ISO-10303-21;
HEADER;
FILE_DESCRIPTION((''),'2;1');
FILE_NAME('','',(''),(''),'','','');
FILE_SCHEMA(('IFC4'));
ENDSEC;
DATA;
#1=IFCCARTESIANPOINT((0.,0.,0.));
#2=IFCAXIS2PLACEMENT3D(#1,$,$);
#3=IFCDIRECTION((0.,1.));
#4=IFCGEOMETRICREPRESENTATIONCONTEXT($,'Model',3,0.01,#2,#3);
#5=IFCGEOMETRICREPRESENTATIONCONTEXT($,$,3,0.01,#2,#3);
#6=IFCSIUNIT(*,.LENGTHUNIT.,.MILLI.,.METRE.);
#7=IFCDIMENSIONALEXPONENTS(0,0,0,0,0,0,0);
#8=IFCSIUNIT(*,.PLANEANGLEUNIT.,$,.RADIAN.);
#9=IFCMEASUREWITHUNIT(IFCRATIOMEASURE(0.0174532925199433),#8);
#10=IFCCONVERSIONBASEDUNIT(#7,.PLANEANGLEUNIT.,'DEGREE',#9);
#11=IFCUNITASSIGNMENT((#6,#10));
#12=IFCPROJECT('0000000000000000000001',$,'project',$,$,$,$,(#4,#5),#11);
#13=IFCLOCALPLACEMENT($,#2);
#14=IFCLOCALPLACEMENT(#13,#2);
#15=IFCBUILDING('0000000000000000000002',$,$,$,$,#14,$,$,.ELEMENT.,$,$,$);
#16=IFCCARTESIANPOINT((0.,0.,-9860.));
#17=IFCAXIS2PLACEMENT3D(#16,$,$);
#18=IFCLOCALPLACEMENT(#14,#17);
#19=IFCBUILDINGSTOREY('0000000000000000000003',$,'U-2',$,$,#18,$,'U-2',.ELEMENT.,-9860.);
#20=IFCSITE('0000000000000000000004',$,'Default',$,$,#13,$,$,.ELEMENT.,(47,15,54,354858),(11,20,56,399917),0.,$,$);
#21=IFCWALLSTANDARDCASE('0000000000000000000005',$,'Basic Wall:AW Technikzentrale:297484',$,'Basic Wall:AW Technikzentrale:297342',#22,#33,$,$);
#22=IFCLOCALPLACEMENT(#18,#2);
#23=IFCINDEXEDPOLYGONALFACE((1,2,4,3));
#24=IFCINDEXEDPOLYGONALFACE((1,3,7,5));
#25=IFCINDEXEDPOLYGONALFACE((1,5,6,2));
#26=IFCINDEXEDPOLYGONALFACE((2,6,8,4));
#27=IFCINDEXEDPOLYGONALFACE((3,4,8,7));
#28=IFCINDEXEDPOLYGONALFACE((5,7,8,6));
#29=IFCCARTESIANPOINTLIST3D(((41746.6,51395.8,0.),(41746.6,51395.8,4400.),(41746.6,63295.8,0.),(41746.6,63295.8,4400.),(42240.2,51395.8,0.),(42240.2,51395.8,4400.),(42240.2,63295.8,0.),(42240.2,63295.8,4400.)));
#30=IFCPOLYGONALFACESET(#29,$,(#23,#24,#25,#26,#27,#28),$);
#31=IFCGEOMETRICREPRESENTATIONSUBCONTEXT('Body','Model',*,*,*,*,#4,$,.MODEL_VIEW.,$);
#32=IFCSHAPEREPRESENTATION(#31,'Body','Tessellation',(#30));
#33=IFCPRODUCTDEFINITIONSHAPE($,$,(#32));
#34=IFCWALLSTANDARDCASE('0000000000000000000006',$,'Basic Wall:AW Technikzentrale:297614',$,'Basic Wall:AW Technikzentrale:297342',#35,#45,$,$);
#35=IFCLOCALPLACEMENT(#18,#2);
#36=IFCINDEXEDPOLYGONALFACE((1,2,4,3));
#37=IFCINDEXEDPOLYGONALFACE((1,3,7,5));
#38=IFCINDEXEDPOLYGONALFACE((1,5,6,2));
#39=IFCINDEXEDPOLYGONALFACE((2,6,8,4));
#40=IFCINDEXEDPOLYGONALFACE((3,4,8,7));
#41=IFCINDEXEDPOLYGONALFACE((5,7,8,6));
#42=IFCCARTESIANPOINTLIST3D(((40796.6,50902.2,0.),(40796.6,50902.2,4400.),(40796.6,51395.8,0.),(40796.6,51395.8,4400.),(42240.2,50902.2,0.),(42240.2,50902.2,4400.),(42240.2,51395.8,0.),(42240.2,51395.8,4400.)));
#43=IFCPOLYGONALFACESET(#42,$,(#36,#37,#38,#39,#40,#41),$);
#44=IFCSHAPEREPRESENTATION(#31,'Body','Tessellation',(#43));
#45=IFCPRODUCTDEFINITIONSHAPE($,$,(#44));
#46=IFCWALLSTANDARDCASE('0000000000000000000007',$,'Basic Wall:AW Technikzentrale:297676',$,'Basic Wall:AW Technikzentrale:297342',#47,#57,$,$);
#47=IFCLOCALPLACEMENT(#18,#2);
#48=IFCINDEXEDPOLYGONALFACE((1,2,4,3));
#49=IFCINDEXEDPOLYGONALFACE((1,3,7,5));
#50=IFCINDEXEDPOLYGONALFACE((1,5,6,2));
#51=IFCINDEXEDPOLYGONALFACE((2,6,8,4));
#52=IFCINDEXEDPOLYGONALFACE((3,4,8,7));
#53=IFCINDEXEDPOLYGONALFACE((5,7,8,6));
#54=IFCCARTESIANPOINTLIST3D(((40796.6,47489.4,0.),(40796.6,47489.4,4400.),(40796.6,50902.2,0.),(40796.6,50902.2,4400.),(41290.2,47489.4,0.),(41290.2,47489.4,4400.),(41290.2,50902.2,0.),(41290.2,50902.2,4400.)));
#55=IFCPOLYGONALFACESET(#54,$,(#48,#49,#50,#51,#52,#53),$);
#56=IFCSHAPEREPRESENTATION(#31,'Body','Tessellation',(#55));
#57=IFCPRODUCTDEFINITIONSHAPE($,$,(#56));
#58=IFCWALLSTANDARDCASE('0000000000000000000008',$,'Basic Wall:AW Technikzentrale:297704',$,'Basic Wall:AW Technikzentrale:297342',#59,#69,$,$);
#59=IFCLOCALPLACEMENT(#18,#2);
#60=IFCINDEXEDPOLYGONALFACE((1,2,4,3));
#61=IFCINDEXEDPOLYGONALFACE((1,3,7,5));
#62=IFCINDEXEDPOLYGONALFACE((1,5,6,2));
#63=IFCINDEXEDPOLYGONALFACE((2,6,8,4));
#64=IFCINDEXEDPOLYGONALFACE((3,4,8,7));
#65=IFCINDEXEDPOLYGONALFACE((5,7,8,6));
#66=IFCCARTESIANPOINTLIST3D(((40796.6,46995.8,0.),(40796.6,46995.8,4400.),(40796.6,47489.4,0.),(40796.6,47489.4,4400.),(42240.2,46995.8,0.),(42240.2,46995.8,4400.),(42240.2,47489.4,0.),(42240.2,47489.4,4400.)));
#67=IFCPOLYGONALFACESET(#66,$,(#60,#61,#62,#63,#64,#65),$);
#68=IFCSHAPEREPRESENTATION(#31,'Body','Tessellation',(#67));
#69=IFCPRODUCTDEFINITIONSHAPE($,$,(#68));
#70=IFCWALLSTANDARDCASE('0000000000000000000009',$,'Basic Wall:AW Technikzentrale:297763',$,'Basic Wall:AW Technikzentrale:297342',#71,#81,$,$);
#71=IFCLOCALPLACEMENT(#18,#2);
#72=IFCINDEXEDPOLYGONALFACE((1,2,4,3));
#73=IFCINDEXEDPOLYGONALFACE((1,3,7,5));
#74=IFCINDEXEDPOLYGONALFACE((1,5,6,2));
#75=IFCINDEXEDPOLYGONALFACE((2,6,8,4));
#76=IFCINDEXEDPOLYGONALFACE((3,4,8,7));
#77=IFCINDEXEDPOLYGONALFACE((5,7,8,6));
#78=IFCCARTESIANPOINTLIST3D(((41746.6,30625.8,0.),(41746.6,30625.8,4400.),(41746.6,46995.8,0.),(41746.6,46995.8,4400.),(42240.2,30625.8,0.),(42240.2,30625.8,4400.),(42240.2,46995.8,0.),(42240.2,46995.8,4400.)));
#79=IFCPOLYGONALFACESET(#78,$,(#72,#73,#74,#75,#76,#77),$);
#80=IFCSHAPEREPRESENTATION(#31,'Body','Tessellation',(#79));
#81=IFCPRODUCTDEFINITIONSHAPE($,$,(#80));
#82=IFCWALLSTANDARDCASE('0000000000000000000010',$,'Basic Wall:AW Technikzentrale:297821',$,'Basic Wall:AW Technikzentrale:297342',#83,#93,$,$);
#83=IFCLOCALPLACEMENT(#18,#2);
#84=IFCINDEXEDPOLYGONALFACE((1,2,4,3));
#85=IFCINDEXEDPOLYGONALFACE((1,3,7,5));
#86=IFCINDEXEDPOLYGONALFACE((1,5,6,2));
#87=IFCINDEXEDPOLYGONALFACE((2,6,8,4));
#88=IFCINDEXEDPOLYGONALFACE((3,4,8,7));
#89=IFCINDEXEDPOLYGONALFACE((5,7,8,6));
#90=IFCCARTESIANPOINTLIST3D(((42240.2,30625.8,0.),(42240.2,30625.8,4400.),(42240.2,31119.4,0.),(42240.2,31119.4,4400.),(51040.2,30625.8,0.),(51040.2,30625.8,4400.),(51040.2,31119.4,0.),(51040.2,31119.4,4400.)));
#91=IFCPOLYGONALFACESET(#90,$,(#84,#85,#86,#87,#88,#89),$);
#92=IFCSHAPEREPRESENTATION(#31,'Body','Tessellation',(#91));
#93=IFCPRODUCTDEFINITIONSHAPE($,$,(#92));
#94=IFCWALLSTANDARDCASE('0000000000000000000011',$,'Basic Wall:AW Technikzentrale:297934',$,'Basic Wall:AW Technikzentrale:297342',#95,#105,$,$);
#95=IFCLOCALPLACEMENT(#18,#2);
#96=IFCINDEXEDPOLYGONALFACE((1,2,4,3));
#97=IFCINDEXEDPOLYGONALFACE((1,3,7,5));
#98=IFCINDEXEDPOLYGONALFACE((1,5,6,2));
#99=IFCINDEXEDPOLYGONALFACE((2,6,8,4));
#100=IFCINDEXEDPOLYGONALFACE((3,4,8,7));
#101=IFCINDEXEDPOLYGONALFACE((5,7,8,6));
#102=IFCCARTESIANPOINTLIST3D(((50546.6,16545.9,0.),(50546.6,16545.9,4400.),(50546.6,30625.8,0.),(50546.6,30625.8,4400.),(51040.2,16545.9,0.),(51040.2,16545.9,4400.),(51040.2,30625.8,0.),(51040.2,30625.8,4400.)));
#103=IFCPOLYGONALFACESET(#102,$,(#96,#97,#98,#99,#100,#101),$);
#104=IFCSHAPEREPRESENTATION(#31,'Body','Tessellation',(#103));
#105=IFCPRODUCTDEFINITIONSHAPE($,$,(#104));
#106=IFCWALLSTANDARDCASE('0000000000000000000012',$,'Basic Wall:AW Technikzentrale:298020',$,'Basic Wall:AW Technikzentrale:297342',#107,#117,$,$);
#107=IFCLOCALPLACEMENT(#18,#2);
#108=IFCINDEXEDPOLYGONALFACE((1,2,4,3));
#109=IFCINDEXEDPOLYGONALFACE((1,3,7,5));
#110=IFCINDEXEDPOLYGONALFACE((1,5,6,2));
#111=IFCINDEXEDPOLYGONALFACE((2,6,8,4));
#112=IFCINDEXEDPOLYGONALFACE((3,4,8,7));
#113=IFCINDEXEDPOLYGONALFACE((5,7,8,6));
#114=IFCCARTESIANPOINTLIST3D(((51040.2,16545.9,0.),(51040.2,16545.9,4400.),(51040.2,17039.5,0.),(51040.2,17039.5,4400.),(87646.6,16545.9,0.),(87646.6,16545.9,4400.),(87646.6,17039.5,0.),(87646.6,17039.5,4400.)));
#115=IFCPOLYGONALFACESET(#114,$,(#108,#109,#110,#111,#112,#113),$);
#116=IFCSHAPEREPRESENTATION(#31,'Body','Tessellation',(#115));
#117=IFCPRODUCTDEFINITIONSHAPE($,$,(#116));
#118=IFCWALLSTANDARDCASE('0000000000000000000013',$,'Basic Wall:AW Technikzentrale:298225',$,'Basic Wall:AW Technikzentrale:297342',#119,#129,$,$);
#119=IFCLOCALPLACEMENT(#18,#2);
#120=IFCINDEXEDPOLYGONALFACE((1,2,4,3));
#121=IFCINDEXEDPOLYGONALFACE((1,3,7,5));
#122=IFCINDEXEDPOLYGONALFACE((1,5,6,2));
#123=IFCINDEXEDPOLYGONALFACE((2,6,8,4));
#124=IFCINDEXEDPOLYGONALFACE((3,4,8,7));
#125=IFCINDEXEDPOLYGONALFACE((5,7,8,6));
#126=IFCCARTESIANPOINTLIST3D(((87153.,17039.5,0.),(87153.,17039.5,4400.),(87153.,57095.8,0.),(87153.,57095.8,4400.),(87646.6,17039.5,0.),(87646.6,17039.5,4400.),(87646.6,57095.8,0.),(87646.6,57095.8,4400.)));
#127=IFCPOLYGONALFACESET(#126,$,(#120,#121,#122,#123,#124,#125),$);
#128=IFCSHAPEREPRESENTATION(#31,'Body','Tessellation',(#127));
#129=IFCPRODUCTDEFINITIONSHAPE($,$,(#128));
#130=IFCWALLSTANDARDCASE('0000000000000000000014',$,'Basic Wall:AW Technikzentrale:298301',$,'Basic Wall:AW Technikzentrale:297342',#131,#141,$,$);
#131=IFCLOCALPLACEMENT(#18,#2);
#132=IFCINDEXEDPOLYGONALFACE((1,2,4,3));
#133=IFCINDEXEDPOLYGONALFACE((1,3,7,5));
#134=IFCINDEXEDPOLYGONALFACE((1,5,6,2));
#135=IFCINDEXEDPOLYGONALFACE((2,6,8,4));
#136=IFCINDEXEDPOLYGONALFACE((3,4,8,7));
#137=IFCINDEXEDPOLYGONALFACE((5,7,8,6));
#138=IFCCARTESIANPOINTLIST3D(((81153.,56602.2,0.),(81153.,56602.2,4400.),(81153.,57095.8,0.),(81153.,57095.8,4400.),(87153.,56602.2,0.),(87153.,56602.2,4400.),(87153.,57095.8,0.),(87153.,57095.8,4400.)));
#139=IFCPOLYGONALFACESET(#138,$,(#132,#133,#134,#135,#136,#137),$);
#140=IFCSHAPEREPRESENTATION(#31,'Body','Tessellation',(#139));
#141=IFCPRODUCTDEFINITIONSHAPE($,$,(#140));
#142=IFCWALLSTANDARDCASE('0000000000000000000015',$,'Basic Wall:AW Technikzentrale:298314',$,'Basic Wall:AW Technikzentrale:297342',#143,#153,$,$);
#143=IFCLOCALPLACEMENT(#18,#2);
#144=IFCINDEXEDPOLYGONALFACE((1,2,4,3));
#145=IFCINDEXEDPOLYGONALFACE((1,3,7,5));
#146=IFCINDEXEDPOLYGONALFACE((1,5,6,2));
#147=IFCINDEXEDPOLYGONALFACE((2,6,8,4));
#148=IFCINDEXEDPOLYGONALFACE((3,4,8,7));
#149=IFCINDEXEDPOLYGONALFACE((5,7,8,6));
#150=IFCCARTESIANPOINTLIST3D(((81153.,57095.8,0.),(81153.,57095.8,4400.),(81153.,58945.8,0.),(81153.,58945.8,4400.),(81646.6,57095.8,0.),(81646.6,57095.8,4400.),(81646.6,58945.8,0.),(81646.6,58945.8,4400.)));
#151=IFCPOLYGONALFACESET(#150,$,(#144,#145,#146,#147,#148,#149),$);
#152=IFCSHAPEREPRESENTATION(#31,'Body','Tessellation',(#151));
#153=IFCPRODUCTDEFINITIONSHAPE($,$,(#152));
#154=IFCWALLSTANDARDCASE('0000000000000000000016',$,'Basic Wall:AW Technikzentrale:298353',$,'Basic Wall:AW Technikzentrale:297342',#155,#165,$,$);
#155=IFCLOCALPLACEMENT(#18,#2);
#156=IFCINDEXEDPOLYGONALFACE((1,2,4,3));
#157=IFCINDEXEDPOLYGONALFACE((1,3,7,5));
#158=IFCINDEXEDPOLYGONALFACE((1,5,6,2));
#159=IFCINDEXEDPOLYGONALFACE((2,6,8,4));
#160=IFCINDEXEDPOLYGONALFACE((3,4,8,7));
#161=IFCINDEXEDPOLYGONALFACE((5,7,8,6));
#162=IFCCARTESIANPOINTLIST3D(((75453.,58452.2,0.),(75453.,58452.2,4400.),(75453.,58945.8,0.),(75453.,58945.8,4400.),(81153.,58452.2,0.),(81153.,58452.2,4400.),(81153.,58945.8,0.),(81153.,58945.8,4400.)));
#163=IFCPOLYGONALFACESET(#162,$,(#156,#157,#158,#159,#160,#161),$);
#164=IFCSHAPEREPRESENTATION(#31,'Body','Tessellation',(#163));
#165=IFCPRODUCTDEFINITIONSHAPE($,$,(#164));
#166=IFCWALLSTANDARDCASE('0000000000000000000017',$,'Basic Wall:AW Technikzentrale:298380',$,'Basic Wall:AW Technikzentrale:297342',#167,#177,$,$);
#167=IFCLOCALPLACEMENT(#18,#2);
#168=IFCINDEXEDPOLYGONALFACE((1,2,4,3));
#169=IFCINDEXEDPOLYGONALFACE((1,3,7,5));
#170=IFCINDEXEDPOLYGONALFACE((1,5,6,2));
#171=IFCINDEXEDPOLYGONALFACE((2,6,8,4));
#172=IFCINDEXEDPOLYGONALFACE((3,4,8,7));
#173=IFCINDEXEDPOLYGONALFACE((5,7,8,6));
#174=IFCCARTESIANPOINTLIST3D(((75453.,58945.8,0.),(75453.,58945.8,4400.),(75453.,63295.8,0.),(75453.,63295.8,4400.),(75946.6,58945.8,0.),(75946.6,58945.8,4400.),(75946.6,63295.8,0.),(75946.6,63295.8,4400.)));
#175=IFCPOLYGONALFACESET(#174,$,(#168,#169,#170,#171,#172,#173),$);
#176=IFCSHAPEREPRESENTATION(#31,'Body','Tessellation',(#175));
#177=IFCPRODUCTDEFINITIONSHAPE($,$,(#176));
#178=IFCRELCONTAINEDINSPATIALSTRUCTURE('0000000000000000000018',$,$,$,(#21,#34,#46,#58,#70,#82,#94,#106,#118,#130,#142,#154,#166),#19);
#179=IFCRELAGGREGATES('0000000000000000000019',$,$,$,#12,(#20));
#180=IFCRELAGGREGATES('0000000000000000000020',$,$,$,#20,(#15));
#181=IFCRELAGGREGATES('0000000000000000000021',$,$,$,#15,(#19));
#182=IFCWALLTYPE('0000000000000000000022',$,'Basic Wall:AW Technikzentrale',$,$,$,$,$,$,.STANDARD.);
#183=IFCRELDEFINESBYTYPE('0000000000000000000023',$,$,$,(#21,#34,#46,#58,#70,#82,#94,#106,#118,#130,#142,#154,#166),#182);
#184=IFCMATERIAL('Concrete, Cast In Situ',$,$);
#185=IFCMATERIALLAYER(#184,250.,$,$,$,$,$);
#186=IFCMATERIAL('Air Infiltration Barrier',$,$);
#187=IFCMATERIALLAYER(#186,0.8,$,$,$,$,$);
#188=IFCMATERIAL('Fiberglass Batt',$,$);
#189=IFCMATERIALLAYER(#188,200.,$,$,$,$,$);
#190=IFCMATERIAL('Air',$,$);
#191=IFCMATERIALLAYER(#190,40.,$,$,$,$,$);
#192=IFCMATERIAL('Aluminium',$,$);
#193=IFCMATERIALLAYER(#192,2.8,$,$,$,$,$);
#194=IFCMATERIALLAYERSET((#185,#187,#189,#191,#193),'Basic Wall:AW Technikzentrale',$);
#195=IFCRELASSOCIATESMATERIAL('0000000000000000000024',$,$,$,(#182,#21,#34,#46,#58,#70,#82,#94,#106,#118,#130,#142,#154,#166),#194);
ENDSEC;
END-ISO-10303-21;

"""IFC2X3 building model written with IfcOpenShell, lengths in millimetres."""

from ifc_helpers import new_model, entity, si_unit, converted_unit, direction, frame, frame_2d, origin, place, context, subcontext, project, spatial, rectangle, extrude, material, layer, layer_set, layer_usage, type_object, element, save


model = new_model("IFC2X3")

# Units and contexts
model_context = context("Model", 3, precision=0.01, world=origin(), true_north=direction((0.0, 1.0)))
context_of_model = context(None, 3, precision=0.01, world=origin(), true_north=direction((0.0, 1.0)))
body_context = subcontext(model_context, "Body", "Model", "MODEL_VIEW")
ifc_project = project(units=[si_unit("LENGTHUNIT", "METRE", prefix="MILLI"), converted_unit("PLANEANGLEUNIT", "DEGREE", entity("IfcRatioMeasure", 0.0174532925199433), si_unit("PLANEANGLEUNIT", "RADIAN"), dimensions=[0, 0, 0, 0, 0, 0, 0])], contexts=[model_context, context_of_model])

# Site, building, storey
site_placement = place(None, origin())
site = spatial("IfcSite", under=ifc_project, at=site_placement, Name="Default", CompositionType="ELEMENT", RefLatitude=(47, 15, 54, 354858), RefLongitude=(11, 20, 56, 399917), RefElevation=0.0)
building_placement = place(site_placement, origin())
building = spatial("IfcBuilding", under=site, at=building_placement, CompositionType="ELEMENT")
storey_placement = place(building_placement, frame((0.0, 0.0, -9860.0)))
storey = spatial("IfcBuildingStorey", under=building, at=storey_placement, Name="U-2", LongName="U-2", CompositionType="ELEMENT", Elevation=-9860.0)

# Shared definitions
ifc_material_1 = material(Name="Air Infiltration Barrier")
ifc_material_2 = material(Name="Fiberglass Batt")

# Walls
ifc_material_3 = material(Name="Concrete, Cast In Situ")
ifc_layer_1 = layer(ifc_material_3, 250.0)
ifc_layer_2 = layer(ifc_material_1, 0.8)
ifc_layer_3 = layer(ifc_material_2, 200.0)
ifc_material_4 = material(Name="Air")
ifc_layer_4 = layer(ifc_material_4, 40.0)
ifc_material_5 = material(Name="Aluminium")
ifc_layer_5 = layer(ifc_material_5, 2.8)
ifc_layer_set_1 = layer_set([ifc_layer_1, ifc_layer_2, ifc_layer_3, ifc_layer_4, ifc_layer_5], Name="Basic Wall:AW Technikzentrale")
ifc_layer_usage_1 = layer_usage(ifc_layer_set_1, "AXIS2", "NEGATIVE", 246.8)
wall_type_1 = type_object("IfcWallType", Name="Basic Wall:AW Technikzentrale", PredefinedType="STANDARD", material=ifc_layer_set_1)
wall_1_placement = place(storey_placement, frame((41993.4, 63295.8, 0.0), z_axis=(0.0, 0.0, 1.0), x_axis=(0.0, -1.0, 0.0)))
element("IfcWallStandardCase", 1, at=wall_1_placement, inside=storey, type_object=wall_type_1, material=ifc_layer_usage_1, Name="Basic Wall:AW Technikzentrale:297484", ObjectType="Basic Wall:AW Technikzentrale:297342", context=body_context, shape_type="SweptSolid", body=[
    extrude(rectangle(XDim=11900.0, YDim=493.6, at=frame_2d((5950.0, 0.0), x_axis=(-1.0, 0.0))), origin(), (0.0, 0.0, 1.0), 4400.0),
])
ifc_layer_usage_2 = layer_usage(ifc_layer_set_1, "AXIS2", "NEGATIVE", 246.8)
wall_2_placement = place(storey_placement, frame((42240.2, 51149.0, 0.0), z_axis=(0.0, 0.0, 1.0), x_axis=(-1.0, 0.0, 0.0)))
element("IfcWallStandardCase", 2, at=wall_2_placement, inside=storey, type_object=wall_type_1, material=ifc_layer_usage_2, Name="Basic Wall:AW Technikzentrale:297614", ObjectType="Basic Wall:AW Technikzentrale:297342", context=body_context, shape_type="SweptSolid", body=[
    extrude(rectangle(XDim=1443.6, YDim=493.6, at=frame_2d((721.8, 0.0), x_axis=(-1.0, 0.0))), origin(), (0.0, 0.0, 1.0), 4400.0),
])
ifc_layer_usage_3 = layer_usage(ifc_layer_set_1, "AXIS2", "NEGATIVE", 246.8)
wall_3_placement = place(storey_placement, frame((41043.4, 50902.2, 0.0), z_axis=(0.0, 0.0, 1.0), x_axis=(0.0, -1.0, 0.0)))
element("IfcWallStandardCase", 3, at=wall_3_placement, inside=storey, type_object=wall_type_1, material=ifc_layer_usage_3, Name="Basic Wall:AW Technikzentrale:297676", ObjectType="Basic Wall:AW Technikzentrale:297342", context=body_context, shape_type="SweptSolid", body=[
    extrude(rectangle(XDim=3412.8, YDim=493.6, at=frame_2d((1706.4, 0.0), x_axis=(-1.0, 0.0))), origin(), (0.0, 0.0, 1.0), 4400.0),
])
ifc_layer_usage_4 = layer_usage(ifc_layer_set_1, "AXIS2", "NEGATIVE", 246.8)
wall_4_placement = place(storey_placement, frame((40796.6, 47242.6, 0.0)))
element("IfcWallStandardCase", 4, at=wall_4_placement, inside=storey, type_object=wall_type_1, material=ifc_layer_usage_4, Name="Basic Wall:AW Technikzentrale:297704", ObjectType="Basic Wall:AW Technikzentrale:297342", context=body_context, shape_type="SweptSolid", body=[
    extrude(rectangle(XDim=1443.6, YDim=493.6, at=frame_2d((721.8, 0.0), x_axis=(-1.0, 0.0))), origin(), (0.0, 0.0, 1.0), 4400.0),
])
ifc_layer_usage_5 = layer_usage(ifc_layer_set_1, "AXIS2", "NEGATIVE", 246.8)
wall_5_placement = place(storey_placement, frame((41993.4, 46995.8, 0.0), z_axis=(0.0, 0.0, 1.0), x_axis=(0.0, -1.0, 0.0)))
element("IfcWallStandardCase", 5, at=wall_5_placement, inside=storey, type_object=wall_type_1, material=ifc_layer_usage_5, Name="Basic Wall:AW Technikzentrale:297763", ObjectType="Basic Wall:AW Technikzentrale:297342", context=body_context, shape_type="SweptSolid", body=[
    extrude(rectangle(XDim=16370.0, YDim=493.6, at=frame_2d((8185.0, 0.0), x_axis=(-1.0, 0.0))), origin(), (0.0, 0.0, 1.0), 4400.0),
])
ifc_layer_usage_6 = layer_usage(ifc_layer_set_1, "AXIS2", "NEGATIVE", 246.8)
wall_6_placement = place(storey_placement, frame((42240.2, 30872.6, 0.0)))
element("IfcWallStandardCase", 6, at=wall_6_placement, inside=storey, type_object=wall_type_1, material=ifc_layer_usage_6, Name="Basic Wall:AW Technikzentrale:297821", ObjectType="Basic Wall:AW Technikzentrale:297342", context=body_context, shape_type="SweptSolid", body=[
    extrude(rectangle(XDim=8800.0, YDim=493.6, at=frame_2d((4400.0, 0.0), x_axis=(-1.0, 0.0))), origin(), (0.0, 0.0, 1.0), 4400.0),
])
ifc_layer_usage_7 = layer_usage(ifc_layer_set_1, "AXIS2", "NEGATIVE", 246.8)
wall_7_placement = place(storey_placement, frame((50793.4, 30625.8, 0.0), z_axis=(0.0, 0.0, 1.0), x_axis=(0.0, -1.0, 0.0)))
element("IfcWallStandardCase", 7, at=wall_7_placement, inside=storey, type_object=wall_type_1, material=ifc_layer_usage_7, Name="Basic Wall:AW Technikzentrale:297934", ObjectType="Basic Wall:AW Technikzentrale:297342", context=body_context, shape_type="SweptSolid", body=[
    extrude(rectangle(XDim=14080.0, YDim=493.6, at=frame_2d((7040.0, 0.0), x_axis=(-1.0, 0.0))), origin(), (0.0, 0.0, 1.0), 4400.0),
])
ifc_layer_usage_8 = layer_usage(ifc_layer_set_1, "AXIS2", "NEGATIVE", 246.8)
wall_8_placement = place(storey_placement, frame((51040.2, 16792.7, 0.0)))
element("IfcWallStandardCase", 8, at=wall_8_placement, inside=storey, type_object=wall_type_1, material=ifc_layer_usage_8, Name="Basic Wall:AW Technikzentrale:298020", ObjectType="Basic Wall:AW Technikzentrale:297342", context=body_context, shape_type="SweptSolid", body=[
    extrude(rectangle(XDim=36606.4, YDim=493.6, at=frame_2d((18303.2, 0.0), x_axis=(-1.0, 0.0))), origin(), (0.0, 0.0, 1.0), 4400.0),
])
ifc_layer_usage_9 = layer_usage(ifc_layer_set_1, "AXIS2", "NEGATIVE", 246.8)
wall_9_placement = place(storey_placement, frame((87399.8, 17039.5, 0.0), z_axis=(0.0, 0.0, 1.0), x_axis=(0.0, 1.0, 0.0)))
element("IfcWallStandardCase", 9, at=wall_9_placement, inside=storey, type_object=wall_type_1, material=ifc_layer_usage_9, Name="Basic Wall:AW Technikzentrale:298225", ObjectType="Basic Wall:AW Technikzentrale:297342", context=body_context, shape_type="SweptSolid", body=[
    extrude(rectangle(XDim=40056.4, YDim=493.6, at=frame_2d((20028.2, 0.0), x_axis=(-1.0, 0.0))), origin(), (0.0, 0.0, 1.0), 4400.0),
])
ifc_layer_usage_10 = layer_usage(ifc_layer_set_1, "AXIS2", "NEGATIVE", 246.8)
wall_10_placement = place(storey_placement, frame((87153.0, 56849.0, 0.0), z_axis=(0.0, 0.0, 1.0), x_axis=(-1.0, 0.0, 0.0)))
element("IfcWallStandardCase", 10, at=wall_10_placement, inside=storey, type_object=wall_type_1, material=ifc_layer_usage_10, Name="Basic Wall:AW Technikzentrale:298301", ObjectType="Basic Wall:AW Technikzentrale:297342", context=body_context, shape_type="SweptSolid", body=[
    extrude(rectangle(XDim=6000.0, YDim=493.6, at=frame_2d((3000.0, 0.0), x_axis=(-1.0, 0.0))), origin(), (0.0, 0.0, 1.0), 4400.0),
])
ifc_layer_usage_11 = layer_usage(ifc_layer_set_1, "AXIS2", "NEGATIVE", 246.8)
wall_11_placement = place(storey_placement, frame((81399.8, 57095.8, 0.0), z_axis=(0.0, 0.0, 1.0), x_axis=(0.0, 1.0, 0.0)))
element("IfcWallStandardCase", 11, at=wall_11_placement, inside=storey, type_object=wall_type_1, material=ifc_layer_usage_11, Name="Basic Wall:AW Technikzentrale:298314", ObjectType="Basic Wall:AW Technikzentrale:297342", context=body_context, shape_type="SweptSolid", body=[
    extrude(rectangle(XDim=1850.0, YDim=493.6, at=frame_2d((925.0, 0.0), x_axis=(-1.0, 0.0))), origin(), (0.0, 0.0, 1.0), 4400.0),
])
ifc_layer_usage_12 = layer_usage(ifc_layer_set_1, "AXIS2", "NEGATIVE", 246.8)
wall_12_placement = place(storey_placement, frame((81153.0, 58699.0, 0.0), z_axis=(0.0, 0.0, 1.0), x_axis=(-1.0, 0.0, 0.0)))
element("IfcWallStandardCase", 12, at=wall_12_placement, inside=storey, type_object=wall_type_1, material=ifc_layer_usage_12, Name="Basic Wall:AW Technikzentrale:298353", ObjectType="Basic Wall:AW Technikzentrale:297342", context=body_context, shape_type="SweptSolid", body=[
    extrude(rectangle(XDim=5700.0, YDim=493.6, at=frame_2d((2850.0, 0.0), x_axis=(-1.0, 0.0))), origin(), (0.0, 0.0, 1.0), 4400.0),
])
ifc_layer_usage_13 = layer_usage(ifc_layer_set_1, "AXIS2", "NEGATIVE", 246.8)
wall_13_placement = place(storey_placement, frame((75699.8, 58945.8, 0.0), z_axis=(0.0, 0.0, 1.0), x_axis=(0.0, 1.0, 0.0)))
element("IfcWallStandardCase", 13, at=wall_13_placement, inside=storey, type_object=wall_type_1, material=ifc_layer_usage_13, Name="Basic Wall:AW Technikzentrale:298380", ObjectType="Basic Wall:AW Technikzentrale:297342", context=body_context, shape_type="SweptSolid", body=[
    extrude(rectangle(XDim=4350.0, YDim=493.6, at=frame_2d((2175.0, 0.0), x_axis=(-1.0, 0.0))), origin(), (0.0, 0.0, 1.0), 4400.0),
])

save(model, "model.ifc")
